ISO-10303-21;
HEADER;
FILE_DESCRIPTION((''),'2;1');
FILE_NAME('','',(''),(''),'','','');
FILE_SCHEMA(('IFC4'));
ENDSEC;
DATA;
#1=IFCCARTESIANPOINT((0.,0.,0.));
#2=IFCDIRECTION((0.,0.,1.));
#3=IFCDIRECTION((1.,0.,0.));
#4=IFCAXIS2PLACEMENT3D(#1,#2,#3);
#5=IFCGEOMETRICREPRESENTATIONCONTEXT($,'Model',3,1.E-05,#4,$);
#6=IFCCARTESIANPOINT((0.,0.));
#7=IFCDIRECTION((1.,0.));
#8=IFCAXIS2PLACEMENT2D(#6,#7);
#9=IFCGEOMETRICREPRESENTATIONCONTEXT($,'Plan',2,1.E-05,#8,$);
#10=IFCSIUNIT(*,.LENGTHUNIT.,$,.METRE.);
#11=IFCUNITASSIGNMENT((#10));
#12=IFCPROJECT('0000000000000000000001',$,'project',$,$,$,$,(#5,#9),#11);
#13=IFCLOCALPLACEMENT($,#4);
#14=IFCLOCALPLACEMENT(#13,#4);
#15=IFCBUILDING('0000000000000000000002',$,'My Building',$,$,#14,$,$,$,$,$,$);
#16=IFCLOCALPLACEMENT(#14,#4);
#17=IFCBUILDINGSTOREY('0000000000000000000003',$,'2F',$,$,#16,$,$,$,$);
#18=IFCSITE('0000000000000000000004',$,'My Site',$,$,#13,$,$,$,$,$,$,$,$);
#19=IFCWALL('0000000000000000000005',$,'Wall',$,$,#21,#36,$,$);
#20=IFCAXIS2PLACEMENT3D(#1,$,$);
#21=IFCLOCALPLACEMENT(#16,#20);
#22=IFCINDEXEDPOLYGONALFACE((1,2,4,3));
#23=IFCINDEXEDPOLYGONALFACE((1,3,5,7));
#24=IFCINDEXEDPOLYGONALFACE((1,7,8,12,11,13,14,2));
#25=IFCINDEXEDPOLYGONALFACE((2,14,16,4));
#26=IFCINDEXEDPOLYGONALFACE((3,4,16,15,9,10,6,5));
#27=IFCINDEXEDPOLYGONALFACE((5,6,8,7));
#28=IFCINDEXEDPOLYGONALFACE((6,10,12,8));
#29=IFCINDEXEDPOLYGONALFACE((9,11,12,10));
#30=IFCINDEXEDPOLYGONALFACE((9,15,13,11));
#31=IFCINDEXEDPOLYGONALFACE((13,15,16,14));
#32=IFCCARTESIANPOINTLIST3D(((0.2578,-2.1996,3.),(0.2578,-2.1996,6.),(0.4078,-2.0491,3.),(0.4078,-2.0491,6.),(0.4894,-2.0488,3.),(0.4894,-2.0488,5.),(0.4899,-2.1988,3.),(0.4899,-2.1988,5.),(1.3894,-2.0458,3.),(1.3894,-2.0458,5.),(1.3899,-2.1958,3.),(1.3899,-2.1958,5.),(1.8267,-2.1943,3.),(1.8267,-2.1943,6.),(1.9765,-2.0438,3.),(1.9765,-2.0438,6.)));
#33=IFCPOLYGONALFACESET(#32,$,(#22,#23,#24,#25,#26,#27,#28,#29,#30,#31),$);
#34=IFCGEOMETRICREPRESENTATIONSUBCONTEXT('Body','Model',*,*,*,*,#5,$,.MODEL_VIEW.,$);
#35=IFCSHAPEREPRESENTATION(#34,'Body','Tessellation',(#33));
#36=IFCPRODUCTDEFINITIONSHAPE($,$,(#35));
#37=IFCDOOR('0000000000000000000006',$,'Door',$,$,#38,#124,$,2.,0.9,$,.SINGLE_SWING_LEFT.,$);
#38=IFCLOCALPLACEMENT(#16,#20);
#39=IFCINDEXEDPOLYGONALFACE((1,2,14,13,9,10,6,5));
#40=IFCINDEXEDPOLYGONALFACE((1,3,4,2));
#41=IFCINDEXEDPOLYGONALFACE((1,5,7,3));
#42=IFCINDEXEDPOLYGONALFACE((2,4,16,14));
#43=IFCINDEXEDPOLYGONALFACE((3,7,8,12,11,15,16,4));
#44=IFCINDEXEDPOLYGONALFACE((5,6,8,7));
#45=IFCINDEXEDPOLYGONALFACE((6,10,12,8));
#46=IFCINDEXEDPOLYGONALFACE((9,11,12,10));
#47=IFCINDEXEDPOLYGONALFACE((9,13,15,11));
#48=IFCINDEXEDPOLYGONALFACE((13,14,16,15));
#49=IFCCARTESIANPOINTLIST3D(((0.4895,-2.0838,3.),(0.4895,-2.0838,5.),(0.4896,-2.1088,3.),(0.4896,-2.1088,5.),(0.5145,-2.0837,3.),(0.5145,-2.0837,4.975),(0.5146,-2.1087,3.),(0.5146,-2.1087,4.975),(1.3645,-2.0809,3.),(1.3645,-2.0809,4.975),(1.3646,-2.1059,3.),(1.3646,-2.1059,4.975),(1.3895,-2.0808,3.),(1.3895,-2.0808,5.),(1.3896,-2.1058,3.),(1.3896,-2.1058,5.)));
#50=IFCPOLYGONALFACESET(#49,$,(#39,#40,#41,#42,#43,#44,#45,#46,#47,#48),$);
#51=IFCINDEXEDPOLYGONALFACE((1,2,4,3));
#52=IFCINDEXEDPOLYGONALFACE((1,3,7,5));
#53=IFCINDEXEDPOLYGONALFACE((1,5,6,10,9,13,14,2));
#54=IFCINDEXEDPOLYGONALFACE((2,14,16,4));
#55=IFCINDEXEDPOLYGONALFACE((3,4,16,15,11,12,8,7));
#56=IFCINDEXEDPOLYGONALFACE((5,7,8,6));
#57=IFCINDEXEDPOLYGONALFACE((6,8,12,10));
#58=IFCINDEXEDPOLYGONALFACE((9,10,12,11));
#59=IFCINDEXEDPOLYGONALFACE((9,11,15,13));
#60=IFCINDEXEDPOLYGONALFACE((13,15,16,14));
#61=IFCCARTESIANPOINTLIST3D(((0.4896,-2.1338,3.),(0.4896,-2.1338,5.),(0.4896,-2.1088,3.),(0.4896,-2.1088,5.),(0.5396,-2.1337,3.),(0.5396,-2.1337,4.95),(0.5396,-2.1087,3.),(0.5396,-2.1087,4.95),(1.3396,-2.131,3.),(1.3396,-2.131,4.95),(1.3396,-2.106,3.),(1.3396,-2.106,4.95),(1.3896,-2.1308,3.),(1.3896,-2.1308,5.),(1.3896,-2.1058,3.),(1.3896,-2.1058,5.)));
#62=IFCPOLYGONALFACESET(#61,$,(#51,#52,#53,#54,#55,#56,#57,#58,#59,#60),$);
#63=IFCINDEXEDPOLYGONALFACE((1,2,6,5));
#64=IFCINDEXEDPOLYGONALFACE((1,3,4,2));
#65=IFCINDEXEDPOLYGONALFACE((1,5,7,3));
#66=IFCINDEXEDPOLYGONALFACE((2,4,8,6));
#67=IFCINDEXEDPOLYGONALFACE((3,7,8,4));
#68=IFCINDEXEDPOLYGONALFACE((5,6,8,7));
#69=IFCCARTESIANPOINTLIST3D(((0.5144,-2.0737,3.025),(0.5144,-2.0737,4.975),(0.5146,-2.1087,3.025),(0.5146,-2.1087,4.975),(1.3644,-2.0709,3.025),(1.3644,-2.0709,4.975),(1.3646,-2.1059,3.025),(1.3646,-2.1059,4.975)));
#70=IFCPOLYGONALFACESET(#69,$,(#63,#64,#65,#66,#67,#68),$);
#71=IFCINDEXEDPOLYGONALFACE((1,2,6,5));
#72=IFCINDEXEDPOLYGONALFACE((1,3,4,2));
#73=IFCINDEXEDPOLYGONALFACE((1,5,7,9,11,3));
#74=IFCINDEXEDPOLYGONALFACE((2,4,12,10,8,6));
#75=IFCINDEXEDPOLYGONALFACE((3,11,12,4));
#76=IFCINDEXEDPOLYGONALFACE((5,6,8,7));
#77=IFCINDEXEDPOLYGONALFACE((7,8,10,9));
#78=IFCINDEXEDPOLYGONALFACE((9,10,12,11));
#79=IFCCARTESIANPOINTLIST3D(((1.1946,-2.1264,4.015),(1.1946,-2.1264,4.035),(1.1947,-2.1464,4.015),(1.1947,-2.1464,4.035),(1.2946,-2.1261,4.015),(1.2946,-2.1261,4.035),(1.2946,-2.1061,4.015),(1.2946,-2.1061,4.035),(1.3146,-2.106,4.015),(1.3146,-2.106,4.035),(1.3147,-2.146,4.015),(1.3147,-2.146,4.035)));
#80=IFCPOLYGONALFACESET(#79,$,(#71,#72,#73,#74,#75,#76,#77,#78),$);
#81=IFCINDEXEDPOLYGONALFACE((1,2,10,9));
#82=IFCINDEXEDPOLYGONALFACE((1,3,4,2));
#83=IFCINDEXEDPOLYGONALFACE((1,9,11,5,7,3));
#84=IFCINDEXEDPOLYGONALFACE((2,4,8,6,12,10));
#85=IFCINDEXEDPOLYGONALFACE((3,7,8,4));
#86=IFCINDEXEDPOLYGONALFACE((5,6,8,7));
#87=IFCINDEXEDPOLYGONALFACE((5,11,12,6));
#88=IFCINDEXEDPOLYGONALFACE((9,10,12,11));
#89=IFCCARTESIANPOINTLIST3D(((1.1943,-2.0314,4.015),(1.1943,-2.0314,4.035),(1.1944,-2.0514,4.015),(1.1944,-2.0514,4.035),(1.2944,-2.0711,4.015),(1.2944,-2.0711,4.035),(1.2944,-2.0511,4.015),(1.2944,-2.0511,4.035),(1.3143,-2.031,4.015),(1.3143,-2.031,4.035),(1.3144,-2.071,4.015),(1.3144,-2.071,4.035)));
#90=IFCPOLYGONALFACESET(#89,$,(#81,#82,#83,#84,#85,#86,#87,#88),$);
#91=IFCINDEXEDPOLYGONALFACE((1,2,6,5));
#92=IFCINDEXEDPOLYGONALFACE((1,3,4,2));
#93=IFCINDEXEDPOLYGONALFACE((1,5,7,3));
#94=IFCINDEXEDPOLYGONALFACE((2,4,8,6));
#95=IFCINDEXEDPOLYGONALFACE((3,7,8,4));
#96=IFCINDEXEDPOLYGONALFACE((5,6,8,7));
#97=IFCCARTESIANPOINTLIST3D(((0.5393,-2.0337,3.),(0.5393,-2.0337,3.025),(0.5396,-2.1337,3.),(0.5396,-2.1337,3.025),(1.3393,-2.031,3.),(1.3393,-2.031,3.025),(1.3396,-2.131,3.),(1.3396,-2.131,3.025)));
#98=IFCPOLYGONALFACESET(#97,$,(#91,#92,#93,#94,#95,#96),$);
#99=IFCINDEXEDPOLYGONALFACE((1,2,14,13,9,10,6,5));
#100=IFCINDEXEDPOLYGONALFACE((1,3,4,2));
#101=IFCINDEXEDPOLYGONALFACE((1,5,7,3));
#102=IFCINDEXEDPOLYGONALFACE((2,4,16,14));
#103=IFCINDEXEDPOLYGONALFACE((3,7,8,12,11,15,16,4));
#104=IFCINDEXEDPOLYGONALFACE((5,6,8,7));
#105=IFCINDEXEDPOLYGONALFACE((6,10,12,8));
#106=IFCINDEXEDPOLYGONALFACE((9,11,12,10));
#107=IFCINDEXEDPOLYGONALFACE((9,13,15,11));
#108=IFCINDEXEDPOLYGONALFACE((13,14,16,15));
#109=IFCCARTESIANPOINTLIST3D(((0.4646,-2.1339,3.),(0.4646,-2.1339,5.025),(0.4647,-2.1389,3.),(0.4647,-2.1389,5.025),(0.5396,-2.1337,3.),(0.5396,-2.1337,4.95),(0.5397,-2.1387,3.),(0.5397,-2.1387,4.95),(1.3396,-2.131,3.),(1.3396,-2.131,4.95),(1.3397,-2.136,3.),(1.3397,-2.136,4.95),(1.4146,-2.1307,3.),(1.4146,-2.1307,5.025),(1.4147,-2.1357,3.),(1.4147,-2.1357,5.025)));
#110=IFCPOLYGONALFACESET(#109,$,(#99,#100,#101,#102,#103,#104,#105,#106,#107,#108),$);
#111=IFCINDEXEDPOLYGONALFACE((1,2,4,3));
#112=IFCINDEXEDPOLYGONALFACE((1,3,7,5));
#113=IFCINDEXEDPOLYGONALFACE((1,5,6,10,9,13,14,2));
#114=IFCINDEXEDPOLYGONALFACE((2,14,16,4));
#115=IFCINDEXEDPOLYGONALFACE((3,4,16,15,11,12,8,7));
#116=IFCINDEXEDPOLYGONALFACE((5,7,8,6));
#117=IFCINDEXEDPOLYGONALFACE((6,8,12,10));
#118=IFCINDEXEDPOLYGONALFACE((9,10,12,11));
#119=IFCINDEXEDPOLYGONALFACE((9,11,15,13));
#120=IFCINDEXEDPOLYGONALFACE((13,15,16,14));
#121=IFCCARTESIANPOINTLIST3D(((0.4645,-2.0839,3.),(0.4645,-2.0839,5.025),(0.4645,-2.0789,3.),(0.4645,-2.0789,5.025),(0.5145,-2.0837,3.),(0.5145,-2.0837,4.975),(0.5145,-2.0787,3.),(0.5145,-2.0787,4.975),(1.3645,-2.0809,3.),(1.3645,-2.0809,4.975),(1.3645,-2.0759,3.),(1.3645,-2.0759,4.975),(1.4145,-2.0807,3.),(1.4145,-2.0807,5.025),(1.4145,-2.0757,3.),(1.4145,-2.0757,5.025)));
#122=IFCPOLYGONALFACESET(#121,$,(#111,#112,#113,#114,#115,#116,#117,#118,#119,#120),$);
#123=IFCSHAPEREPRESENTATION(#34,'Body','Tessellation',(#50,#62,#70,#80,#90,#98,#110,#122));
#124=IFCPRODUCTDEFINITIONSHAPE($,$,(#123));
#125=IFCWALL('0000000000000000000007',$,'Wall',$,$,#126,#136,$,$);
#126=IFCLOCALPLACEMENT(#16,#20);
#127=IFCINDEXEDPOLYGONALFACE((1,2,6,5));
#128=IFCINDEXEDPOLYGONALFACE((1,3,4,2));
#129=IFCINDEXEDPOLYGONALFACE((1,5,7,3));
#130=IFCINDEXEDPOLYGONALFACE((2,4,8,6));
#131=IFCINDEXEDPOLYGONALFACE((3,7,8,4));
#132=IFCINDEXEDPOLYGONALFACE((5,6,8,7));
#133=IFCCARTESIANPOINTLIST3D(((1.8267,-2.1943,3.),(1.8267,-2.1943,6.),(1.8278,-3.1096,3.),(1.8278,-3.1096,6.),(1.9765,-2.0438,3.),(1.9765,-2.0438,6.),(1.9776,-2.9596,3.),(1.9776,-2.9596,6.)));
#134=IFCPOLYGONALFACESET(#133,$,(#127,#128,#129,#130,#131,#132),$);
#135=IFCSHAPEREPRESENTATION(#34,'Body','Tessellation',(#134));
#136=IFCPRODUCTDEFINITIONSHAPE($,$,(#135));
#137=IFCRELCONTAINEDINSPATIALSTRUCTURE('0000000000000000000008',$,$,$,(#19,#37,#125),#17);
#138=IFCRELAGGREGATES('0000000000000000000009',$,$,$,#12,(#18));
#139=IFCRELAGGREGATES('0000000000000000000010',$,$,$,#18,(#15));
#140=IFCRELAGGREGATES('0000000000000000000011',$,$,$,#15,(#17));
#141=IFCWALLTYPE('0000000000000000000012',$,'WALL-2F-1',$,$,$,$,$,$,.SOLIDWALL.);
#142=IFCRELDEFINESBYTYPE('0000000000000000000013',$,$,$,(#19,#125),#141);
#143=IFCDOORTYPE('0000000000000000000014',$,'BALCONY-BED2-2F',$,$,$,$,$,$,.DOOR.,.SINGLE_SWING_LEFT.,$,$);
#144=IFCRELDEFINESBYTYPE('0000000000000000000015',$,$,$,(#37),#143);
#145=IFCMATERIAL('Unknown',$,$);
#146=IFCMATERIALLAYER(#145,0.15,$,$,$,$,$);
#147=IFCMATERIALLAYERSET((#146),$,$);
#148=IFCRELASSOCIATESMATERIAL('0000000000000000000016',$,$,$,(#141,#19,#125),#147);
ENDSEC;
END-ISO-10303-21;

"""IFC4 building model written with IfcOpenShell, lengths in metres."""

from ifc_helpers import new_model, entity, si_unit, frame, origin_with_axes, origin_2d_with_axis, place, context, subcontext, project, spatial, line, indexed_curve, outline, extrude, shape, source, transform, mapped, material, layer, layer_set, layer_usage, type_object, type_shapes, element, fill, save


model = new_model("IFC4")

# Units and contexts
model_context = context("Model", 3, precision=1e-05, world=origin_with_axes())
plan_context = context("Plan", 2, precision=1e-05, world=origin_2d_with_axis())
body_context_1 = subcontext(model_context, "Body", "Model", "MODEL_VIEW")
body_context_2 = subcontext(plan_context, "Body", "Plan", "PLAN_VIEW")
ifc_project = project(units=[si_unit("LENGTHUNIT", "METRE")], contexts=[model_context, plan_context])

# Site, building, storey
site_placement = place(None, origin_with_axes())
site = spatial("IfcSite", under=ifc_project, at=site_placement, Name="My Site")
building_placement = place(site_placement, origin_with_axes())
building = spatial("IfcBuilding", under=site, at=building_placement, Name="My Building")
storey_placement = place(building_placement, origin_with_axes())
storey = spatial("IfcBuildingStorey", under=building, at=storey_placement, Name="2F")

# Shared definitions
ifc_material = material(Name="Unknown")

# Shared definitions
ifc_layer_1 = layer(ifc_material, 0.15)
ifc_layer_set_1 = layer_set([ifc_layer_1])
wall_type_1 = type_object("IfcWallType", Name="WALL-2F-1", PredefinedType="SOLIDWALL", material=ifc_layer_set_1)

# Wall, opening, door
ifc_layer_usage_1 = layer_usage(ifc_layer_set_1, "AXIS2", "POSITIVE", 0.0)
wall_1_placement = place(storey_placement, frame((0.2578, -2.1996, 3.0), z_axis=(0.0, 0.0, 1.0), x_axis=(0.999994, 0.003371, 0.0)))
wall_1 = element("IfcWall", 1, at=wall_1_placement, inside=storey, type_object=wall_type_1, material=ifc_layer_usage_1, Name="Wall", context=body_context_1, shape_type="SweptSolid", body=[
    extrude(outline(indexed_curve([(0.0, 0.0), (0.1505, 0.15), (1.7192, 0.15), (1.5689, 0.0)], segments=[line(1, 2, 3, 4, 1)])), origin_with_axes(), (0.0, 0.0, 1.0), 3.0),
])
shared_shape_1 = source(origin_with_axes(), body_context_1, "Body", "SweptSolid", [
    extrude(outline(indexed_curve([(0.0, 0.0), (0.9, 0.0), (0.9, 2.0), (0.0, 2.0)], segments=[line(1, 2, 3, 4, 1)])), frame((0.0, -0.6, 0.0), z_axis=(0.0, -1.0, 0.0), x_axis=(1.0, 0.0, 0.0)), (0.0, 0.0, -1.0), 1.2),
])
opening_1_placement = place(wall_1_placement, frame((0.2321, 0.065, 0.0), z_axis=(0.0, 0.0, 1.0), x_axis=(1.0, 0.0, 0.0)))
opening_1 = element("IfcOpeningElement", 2, at=opening_1_placement, cuts=wall_1, PredefinedType="OPENING", context=body_context_1, shape_type="MappedRepresentation", body=[
    mapped(shared_shape_1, transform((0.0, 0.0, 0.0), x_axis=(1.0, 0.0, 0.0), y_axis=(0.0, 1.0, 0.0), z_axis=(0.0, 0.0, 1.0), scale=1.0)),
])
door_type_1 = type_object("IfcDoorType", Name="BALCONY-BED2-2F", OperationType="SINGLE_SWING_LEFT", PredefinedType="DOOR")
shared_shape_2 = source(origin_with_axes(), body_context_1, "Body", "SweptSolid", [
    extrude(outline(indexed_curve([(0.0, 0.0), (0.0, 2.0), (0.9, 2.0), (0.9, 0.0), (0.875, 0.0), (0.875, 1.975), (0.025, 1.975), (0.025, 0.0)], segments=[line(1, 2, 3, 4, 5, 6, 7, 8, 1)])), frame((0.0, 0.025, 0.0), z_axis=(0.0, -1.0, 0.0), x_axis=(1.0, 0.0, 0.0)), (0.0, 0.0, -1.0), 0.025),
    extrude(outline(indexed_curve([(0.0, 0.0), (0.0, 2.0), (0.9, 2.0), (0.9, 0.0), (0.85, 0.0), (0.85, 1.95), (0.05, 1.95), (0.05, 0.0)], segments=[line(1, 2, 3, 4, 5, 6, 7, 8, 1)])), frame((0.0, 0.0, 0.0), z_axis=(0.0, -1.0, 0.0), x_axis=(1.0, 0.0, 0.0)), (0.0, 0.0, -1.0), 0.025),
    extrude(outline(indexed_curve([(0.0, 0.0), (0.85, 0.0), (0.85, 0.035), (0.0, 0.035)], segments=[line(1, 2, 3, 4, 1)])), frame((0.025, 0.025, 0.025), z_axis=(0.0, 0.0, 1.0), x_axis=(1.0, 0.0, 0.0)), (0.0, 0.0, 1.0), 1.95),
    extrude(outline(indexed_curve([(0.0, 0.0), (0.0, -0.04), (-0.12, -0.04), (-0.12, -0.02), (-0.02, -0.02), (-0.02, 0.0)], segments=[line(1, 2, 3, 4, 5, 6, 1)])), frame((0.825, 0.025, 1.015), z_axis=(0.0, 0.0, 1.0), x_axis=(1.0, 0.0, 0.0)), (0.0, 0.0, 1.0), 0.02),
    extrude(outline(indexed_curve([(0.0, 0.0), (0.0, 0.04), (-0.12, 0.04), (-0.12, 0.02), (-0.02, 0.02), (-0.02, 0.0)], segments=[line(1, 2, 3, 4, 5, 6, 1)])), frame((0.825, 0.06, 1.015), z_axis=(0.0, 0.0, 1.0), x_axis=(1.0, 0.0, 0.0)), (0.0, 0.0, 1.0), 0.02),
    extrude(outline(indexed_curve([(0.0, 0.0), (0.8, 0.0), (0.8, 0.1), (0.0, 0.1)], segments=[line(1, 2, 3, 4, 1)])), frame((0.05, 0.0, 0.0), z_axis=(0.0, 0.0, 1.0), x_axis=(1.0, 0.0, 0.0)), (0.0, 0.0, 1.0), 0.025),
    extrude(outline(indexed_curve([(0.0, 0.0), (0.0, 2.025), (0.95, 2.025), (0.95, 0.0), (0.875, 0.0), (0.875, 1.95), (0.075, 1.95), (0.075, 0.0)], segments=[line(1, 2, 3, 4, 5, 6, 7, 8, 1)])), frame((-0.025, -0.005, 0.0), z_axis=(0.0, -1.0, 0.0), x_axis=(1.0, 0.0, 0.0)), (0.0, 0.0, -1.0), 0.005),
    extrude(outline(indexed_curve([(0.0, 0.0), (0.0, 2.025), (0.95, 2.025), (0.95, 0.0), (0.9, 0.0), (0.9, 1.975), (0.05, 1.975), (0.05, 0.0)], segments=[line(1, 2, 3, 4, 5, 6, 7, 8, 1)])), frame((-0.025, 0.05, 0.0), z_axis=(0.0, -1.0, 0.0), x_axis=(1.0, 0.0, 0.0)), (0.0, 0.0, -1.0), 0.005),
])
shared_shape_3 = source(origin_with_axes(), body_context_2, "Body", "Curve2D", [
    entity("IfcIndexedPolyCurve", entity("IfcCartesianPointList2D", [[0.0, 0.0], [0.0, 0.05], [0.025, 0.05], [0.025, 0.025], [0.05, 0.025], [0.05, 0.0]]), [entity("IfcLineIndex", [1, 2, 3, 4, 5, 6, 1])]),
    entity("IfcIndexedPolyCurve", entity("IfcCartesianPointList2D", [[0.9, 0.0], [0.9, 0.05], [0.875, 0.05], [0.875, 0.025], [0.85, 0.025], [0.85, 0.0]]), [entity("IfcLineIndex", [1, 2, 3, 4, 5, 6, 1])]),
    entity("IfcTrimmedCurve", entity("IfcEllipse", entity("IfcAxis2Placement2D", entity("IfcCartesianPoint", [0.06, 0.05]), entity("IfcDirection", [1.0, 0.0])), 0.815, 0.85), [entity("IfcCartesianPoint", [0.875, 0.05])], [entity("IfcCartesianPoint", [0.06, 0.9])], True, "CARTESIAN"),
    entity("IfcIndexedPolyCurve", entity("IfcCartesianPointList2D", [[0.025, 0.05], [0.06, 0.05], [0.06, 0.9], [0.025, 0.9]]), [entity("IfcLineIndex", [1, 2, 3, 4, 1])]),
])
type_shapes(door_type_1, [shared_shape_2, shared_shape_3])
door_1_placement = place(opening_1_placement, frame((0.0, 0.0, 0.0), z_axis=(0.0, 0.0, 1.0), x_axis=(1.0, 0.0, 0.0)))
door_1 = element("IfcDoor", 3, at=door_1_placement, inside=storey, type_object=door_type_1, Name="Door", OperationType="SINGLE_SWING_LEFT", OverallHeight=2.0, OverallWidth=0.9, shapes=[
    shape(body_context_1, "Body", "MappedRepresentation", [mapped(shared_shape_2, transform((0.0, 0.0, 0.0), x_axis=(1.0, 0.0, 0.0), y_axis=(0.0, 1.0, 0.0), z_axis=(0.0, 0.0, 1.0), scale=1.0))]),
    shape(body_context_2, "Body", "MappedRepresentation", [mapped(shared_shape_3, transform((0.0, 0.0, 0.0), x_axis=(1.0, 0.0, 0.0), y_axis=(0.0, 1.0, 0.0), z_axis=(0.0, 0.0, 1.0), scale=1.0))]),
])
fill(opening_1, door_1)

# Wall
ifc_layer_usage_2 = layer_usage(ifc_layer_set_1, "AXIS2", "POSITIVE", 0.0)
wall_2_placement = place(storey_placement, frame((1.8267, -2.1943, 3.0), z_axis=(0.0, 0.0, 1.0), x_axis=(0.001208, -0.999999, 0.0)))
element("IfcWall", 4, at=wall_2_placement, inside=storey, type_object=wall_type_1, material=ifc_layer_usage_2, Name="Wall", context=body_context_1, shape_type="SweptSolid", body=[
    extrude(outline(indexed_curve([(0.0, 0.0), (-0.1503, 0.15), (0.7655, 0.15), (0.9153, 0.0)], segments=[line(1, 2, 3, 4, 1)])), origin_with_axes(), (0.0, 0.0, 1.0), 3.0),
])

save(model, "model.ifc")
